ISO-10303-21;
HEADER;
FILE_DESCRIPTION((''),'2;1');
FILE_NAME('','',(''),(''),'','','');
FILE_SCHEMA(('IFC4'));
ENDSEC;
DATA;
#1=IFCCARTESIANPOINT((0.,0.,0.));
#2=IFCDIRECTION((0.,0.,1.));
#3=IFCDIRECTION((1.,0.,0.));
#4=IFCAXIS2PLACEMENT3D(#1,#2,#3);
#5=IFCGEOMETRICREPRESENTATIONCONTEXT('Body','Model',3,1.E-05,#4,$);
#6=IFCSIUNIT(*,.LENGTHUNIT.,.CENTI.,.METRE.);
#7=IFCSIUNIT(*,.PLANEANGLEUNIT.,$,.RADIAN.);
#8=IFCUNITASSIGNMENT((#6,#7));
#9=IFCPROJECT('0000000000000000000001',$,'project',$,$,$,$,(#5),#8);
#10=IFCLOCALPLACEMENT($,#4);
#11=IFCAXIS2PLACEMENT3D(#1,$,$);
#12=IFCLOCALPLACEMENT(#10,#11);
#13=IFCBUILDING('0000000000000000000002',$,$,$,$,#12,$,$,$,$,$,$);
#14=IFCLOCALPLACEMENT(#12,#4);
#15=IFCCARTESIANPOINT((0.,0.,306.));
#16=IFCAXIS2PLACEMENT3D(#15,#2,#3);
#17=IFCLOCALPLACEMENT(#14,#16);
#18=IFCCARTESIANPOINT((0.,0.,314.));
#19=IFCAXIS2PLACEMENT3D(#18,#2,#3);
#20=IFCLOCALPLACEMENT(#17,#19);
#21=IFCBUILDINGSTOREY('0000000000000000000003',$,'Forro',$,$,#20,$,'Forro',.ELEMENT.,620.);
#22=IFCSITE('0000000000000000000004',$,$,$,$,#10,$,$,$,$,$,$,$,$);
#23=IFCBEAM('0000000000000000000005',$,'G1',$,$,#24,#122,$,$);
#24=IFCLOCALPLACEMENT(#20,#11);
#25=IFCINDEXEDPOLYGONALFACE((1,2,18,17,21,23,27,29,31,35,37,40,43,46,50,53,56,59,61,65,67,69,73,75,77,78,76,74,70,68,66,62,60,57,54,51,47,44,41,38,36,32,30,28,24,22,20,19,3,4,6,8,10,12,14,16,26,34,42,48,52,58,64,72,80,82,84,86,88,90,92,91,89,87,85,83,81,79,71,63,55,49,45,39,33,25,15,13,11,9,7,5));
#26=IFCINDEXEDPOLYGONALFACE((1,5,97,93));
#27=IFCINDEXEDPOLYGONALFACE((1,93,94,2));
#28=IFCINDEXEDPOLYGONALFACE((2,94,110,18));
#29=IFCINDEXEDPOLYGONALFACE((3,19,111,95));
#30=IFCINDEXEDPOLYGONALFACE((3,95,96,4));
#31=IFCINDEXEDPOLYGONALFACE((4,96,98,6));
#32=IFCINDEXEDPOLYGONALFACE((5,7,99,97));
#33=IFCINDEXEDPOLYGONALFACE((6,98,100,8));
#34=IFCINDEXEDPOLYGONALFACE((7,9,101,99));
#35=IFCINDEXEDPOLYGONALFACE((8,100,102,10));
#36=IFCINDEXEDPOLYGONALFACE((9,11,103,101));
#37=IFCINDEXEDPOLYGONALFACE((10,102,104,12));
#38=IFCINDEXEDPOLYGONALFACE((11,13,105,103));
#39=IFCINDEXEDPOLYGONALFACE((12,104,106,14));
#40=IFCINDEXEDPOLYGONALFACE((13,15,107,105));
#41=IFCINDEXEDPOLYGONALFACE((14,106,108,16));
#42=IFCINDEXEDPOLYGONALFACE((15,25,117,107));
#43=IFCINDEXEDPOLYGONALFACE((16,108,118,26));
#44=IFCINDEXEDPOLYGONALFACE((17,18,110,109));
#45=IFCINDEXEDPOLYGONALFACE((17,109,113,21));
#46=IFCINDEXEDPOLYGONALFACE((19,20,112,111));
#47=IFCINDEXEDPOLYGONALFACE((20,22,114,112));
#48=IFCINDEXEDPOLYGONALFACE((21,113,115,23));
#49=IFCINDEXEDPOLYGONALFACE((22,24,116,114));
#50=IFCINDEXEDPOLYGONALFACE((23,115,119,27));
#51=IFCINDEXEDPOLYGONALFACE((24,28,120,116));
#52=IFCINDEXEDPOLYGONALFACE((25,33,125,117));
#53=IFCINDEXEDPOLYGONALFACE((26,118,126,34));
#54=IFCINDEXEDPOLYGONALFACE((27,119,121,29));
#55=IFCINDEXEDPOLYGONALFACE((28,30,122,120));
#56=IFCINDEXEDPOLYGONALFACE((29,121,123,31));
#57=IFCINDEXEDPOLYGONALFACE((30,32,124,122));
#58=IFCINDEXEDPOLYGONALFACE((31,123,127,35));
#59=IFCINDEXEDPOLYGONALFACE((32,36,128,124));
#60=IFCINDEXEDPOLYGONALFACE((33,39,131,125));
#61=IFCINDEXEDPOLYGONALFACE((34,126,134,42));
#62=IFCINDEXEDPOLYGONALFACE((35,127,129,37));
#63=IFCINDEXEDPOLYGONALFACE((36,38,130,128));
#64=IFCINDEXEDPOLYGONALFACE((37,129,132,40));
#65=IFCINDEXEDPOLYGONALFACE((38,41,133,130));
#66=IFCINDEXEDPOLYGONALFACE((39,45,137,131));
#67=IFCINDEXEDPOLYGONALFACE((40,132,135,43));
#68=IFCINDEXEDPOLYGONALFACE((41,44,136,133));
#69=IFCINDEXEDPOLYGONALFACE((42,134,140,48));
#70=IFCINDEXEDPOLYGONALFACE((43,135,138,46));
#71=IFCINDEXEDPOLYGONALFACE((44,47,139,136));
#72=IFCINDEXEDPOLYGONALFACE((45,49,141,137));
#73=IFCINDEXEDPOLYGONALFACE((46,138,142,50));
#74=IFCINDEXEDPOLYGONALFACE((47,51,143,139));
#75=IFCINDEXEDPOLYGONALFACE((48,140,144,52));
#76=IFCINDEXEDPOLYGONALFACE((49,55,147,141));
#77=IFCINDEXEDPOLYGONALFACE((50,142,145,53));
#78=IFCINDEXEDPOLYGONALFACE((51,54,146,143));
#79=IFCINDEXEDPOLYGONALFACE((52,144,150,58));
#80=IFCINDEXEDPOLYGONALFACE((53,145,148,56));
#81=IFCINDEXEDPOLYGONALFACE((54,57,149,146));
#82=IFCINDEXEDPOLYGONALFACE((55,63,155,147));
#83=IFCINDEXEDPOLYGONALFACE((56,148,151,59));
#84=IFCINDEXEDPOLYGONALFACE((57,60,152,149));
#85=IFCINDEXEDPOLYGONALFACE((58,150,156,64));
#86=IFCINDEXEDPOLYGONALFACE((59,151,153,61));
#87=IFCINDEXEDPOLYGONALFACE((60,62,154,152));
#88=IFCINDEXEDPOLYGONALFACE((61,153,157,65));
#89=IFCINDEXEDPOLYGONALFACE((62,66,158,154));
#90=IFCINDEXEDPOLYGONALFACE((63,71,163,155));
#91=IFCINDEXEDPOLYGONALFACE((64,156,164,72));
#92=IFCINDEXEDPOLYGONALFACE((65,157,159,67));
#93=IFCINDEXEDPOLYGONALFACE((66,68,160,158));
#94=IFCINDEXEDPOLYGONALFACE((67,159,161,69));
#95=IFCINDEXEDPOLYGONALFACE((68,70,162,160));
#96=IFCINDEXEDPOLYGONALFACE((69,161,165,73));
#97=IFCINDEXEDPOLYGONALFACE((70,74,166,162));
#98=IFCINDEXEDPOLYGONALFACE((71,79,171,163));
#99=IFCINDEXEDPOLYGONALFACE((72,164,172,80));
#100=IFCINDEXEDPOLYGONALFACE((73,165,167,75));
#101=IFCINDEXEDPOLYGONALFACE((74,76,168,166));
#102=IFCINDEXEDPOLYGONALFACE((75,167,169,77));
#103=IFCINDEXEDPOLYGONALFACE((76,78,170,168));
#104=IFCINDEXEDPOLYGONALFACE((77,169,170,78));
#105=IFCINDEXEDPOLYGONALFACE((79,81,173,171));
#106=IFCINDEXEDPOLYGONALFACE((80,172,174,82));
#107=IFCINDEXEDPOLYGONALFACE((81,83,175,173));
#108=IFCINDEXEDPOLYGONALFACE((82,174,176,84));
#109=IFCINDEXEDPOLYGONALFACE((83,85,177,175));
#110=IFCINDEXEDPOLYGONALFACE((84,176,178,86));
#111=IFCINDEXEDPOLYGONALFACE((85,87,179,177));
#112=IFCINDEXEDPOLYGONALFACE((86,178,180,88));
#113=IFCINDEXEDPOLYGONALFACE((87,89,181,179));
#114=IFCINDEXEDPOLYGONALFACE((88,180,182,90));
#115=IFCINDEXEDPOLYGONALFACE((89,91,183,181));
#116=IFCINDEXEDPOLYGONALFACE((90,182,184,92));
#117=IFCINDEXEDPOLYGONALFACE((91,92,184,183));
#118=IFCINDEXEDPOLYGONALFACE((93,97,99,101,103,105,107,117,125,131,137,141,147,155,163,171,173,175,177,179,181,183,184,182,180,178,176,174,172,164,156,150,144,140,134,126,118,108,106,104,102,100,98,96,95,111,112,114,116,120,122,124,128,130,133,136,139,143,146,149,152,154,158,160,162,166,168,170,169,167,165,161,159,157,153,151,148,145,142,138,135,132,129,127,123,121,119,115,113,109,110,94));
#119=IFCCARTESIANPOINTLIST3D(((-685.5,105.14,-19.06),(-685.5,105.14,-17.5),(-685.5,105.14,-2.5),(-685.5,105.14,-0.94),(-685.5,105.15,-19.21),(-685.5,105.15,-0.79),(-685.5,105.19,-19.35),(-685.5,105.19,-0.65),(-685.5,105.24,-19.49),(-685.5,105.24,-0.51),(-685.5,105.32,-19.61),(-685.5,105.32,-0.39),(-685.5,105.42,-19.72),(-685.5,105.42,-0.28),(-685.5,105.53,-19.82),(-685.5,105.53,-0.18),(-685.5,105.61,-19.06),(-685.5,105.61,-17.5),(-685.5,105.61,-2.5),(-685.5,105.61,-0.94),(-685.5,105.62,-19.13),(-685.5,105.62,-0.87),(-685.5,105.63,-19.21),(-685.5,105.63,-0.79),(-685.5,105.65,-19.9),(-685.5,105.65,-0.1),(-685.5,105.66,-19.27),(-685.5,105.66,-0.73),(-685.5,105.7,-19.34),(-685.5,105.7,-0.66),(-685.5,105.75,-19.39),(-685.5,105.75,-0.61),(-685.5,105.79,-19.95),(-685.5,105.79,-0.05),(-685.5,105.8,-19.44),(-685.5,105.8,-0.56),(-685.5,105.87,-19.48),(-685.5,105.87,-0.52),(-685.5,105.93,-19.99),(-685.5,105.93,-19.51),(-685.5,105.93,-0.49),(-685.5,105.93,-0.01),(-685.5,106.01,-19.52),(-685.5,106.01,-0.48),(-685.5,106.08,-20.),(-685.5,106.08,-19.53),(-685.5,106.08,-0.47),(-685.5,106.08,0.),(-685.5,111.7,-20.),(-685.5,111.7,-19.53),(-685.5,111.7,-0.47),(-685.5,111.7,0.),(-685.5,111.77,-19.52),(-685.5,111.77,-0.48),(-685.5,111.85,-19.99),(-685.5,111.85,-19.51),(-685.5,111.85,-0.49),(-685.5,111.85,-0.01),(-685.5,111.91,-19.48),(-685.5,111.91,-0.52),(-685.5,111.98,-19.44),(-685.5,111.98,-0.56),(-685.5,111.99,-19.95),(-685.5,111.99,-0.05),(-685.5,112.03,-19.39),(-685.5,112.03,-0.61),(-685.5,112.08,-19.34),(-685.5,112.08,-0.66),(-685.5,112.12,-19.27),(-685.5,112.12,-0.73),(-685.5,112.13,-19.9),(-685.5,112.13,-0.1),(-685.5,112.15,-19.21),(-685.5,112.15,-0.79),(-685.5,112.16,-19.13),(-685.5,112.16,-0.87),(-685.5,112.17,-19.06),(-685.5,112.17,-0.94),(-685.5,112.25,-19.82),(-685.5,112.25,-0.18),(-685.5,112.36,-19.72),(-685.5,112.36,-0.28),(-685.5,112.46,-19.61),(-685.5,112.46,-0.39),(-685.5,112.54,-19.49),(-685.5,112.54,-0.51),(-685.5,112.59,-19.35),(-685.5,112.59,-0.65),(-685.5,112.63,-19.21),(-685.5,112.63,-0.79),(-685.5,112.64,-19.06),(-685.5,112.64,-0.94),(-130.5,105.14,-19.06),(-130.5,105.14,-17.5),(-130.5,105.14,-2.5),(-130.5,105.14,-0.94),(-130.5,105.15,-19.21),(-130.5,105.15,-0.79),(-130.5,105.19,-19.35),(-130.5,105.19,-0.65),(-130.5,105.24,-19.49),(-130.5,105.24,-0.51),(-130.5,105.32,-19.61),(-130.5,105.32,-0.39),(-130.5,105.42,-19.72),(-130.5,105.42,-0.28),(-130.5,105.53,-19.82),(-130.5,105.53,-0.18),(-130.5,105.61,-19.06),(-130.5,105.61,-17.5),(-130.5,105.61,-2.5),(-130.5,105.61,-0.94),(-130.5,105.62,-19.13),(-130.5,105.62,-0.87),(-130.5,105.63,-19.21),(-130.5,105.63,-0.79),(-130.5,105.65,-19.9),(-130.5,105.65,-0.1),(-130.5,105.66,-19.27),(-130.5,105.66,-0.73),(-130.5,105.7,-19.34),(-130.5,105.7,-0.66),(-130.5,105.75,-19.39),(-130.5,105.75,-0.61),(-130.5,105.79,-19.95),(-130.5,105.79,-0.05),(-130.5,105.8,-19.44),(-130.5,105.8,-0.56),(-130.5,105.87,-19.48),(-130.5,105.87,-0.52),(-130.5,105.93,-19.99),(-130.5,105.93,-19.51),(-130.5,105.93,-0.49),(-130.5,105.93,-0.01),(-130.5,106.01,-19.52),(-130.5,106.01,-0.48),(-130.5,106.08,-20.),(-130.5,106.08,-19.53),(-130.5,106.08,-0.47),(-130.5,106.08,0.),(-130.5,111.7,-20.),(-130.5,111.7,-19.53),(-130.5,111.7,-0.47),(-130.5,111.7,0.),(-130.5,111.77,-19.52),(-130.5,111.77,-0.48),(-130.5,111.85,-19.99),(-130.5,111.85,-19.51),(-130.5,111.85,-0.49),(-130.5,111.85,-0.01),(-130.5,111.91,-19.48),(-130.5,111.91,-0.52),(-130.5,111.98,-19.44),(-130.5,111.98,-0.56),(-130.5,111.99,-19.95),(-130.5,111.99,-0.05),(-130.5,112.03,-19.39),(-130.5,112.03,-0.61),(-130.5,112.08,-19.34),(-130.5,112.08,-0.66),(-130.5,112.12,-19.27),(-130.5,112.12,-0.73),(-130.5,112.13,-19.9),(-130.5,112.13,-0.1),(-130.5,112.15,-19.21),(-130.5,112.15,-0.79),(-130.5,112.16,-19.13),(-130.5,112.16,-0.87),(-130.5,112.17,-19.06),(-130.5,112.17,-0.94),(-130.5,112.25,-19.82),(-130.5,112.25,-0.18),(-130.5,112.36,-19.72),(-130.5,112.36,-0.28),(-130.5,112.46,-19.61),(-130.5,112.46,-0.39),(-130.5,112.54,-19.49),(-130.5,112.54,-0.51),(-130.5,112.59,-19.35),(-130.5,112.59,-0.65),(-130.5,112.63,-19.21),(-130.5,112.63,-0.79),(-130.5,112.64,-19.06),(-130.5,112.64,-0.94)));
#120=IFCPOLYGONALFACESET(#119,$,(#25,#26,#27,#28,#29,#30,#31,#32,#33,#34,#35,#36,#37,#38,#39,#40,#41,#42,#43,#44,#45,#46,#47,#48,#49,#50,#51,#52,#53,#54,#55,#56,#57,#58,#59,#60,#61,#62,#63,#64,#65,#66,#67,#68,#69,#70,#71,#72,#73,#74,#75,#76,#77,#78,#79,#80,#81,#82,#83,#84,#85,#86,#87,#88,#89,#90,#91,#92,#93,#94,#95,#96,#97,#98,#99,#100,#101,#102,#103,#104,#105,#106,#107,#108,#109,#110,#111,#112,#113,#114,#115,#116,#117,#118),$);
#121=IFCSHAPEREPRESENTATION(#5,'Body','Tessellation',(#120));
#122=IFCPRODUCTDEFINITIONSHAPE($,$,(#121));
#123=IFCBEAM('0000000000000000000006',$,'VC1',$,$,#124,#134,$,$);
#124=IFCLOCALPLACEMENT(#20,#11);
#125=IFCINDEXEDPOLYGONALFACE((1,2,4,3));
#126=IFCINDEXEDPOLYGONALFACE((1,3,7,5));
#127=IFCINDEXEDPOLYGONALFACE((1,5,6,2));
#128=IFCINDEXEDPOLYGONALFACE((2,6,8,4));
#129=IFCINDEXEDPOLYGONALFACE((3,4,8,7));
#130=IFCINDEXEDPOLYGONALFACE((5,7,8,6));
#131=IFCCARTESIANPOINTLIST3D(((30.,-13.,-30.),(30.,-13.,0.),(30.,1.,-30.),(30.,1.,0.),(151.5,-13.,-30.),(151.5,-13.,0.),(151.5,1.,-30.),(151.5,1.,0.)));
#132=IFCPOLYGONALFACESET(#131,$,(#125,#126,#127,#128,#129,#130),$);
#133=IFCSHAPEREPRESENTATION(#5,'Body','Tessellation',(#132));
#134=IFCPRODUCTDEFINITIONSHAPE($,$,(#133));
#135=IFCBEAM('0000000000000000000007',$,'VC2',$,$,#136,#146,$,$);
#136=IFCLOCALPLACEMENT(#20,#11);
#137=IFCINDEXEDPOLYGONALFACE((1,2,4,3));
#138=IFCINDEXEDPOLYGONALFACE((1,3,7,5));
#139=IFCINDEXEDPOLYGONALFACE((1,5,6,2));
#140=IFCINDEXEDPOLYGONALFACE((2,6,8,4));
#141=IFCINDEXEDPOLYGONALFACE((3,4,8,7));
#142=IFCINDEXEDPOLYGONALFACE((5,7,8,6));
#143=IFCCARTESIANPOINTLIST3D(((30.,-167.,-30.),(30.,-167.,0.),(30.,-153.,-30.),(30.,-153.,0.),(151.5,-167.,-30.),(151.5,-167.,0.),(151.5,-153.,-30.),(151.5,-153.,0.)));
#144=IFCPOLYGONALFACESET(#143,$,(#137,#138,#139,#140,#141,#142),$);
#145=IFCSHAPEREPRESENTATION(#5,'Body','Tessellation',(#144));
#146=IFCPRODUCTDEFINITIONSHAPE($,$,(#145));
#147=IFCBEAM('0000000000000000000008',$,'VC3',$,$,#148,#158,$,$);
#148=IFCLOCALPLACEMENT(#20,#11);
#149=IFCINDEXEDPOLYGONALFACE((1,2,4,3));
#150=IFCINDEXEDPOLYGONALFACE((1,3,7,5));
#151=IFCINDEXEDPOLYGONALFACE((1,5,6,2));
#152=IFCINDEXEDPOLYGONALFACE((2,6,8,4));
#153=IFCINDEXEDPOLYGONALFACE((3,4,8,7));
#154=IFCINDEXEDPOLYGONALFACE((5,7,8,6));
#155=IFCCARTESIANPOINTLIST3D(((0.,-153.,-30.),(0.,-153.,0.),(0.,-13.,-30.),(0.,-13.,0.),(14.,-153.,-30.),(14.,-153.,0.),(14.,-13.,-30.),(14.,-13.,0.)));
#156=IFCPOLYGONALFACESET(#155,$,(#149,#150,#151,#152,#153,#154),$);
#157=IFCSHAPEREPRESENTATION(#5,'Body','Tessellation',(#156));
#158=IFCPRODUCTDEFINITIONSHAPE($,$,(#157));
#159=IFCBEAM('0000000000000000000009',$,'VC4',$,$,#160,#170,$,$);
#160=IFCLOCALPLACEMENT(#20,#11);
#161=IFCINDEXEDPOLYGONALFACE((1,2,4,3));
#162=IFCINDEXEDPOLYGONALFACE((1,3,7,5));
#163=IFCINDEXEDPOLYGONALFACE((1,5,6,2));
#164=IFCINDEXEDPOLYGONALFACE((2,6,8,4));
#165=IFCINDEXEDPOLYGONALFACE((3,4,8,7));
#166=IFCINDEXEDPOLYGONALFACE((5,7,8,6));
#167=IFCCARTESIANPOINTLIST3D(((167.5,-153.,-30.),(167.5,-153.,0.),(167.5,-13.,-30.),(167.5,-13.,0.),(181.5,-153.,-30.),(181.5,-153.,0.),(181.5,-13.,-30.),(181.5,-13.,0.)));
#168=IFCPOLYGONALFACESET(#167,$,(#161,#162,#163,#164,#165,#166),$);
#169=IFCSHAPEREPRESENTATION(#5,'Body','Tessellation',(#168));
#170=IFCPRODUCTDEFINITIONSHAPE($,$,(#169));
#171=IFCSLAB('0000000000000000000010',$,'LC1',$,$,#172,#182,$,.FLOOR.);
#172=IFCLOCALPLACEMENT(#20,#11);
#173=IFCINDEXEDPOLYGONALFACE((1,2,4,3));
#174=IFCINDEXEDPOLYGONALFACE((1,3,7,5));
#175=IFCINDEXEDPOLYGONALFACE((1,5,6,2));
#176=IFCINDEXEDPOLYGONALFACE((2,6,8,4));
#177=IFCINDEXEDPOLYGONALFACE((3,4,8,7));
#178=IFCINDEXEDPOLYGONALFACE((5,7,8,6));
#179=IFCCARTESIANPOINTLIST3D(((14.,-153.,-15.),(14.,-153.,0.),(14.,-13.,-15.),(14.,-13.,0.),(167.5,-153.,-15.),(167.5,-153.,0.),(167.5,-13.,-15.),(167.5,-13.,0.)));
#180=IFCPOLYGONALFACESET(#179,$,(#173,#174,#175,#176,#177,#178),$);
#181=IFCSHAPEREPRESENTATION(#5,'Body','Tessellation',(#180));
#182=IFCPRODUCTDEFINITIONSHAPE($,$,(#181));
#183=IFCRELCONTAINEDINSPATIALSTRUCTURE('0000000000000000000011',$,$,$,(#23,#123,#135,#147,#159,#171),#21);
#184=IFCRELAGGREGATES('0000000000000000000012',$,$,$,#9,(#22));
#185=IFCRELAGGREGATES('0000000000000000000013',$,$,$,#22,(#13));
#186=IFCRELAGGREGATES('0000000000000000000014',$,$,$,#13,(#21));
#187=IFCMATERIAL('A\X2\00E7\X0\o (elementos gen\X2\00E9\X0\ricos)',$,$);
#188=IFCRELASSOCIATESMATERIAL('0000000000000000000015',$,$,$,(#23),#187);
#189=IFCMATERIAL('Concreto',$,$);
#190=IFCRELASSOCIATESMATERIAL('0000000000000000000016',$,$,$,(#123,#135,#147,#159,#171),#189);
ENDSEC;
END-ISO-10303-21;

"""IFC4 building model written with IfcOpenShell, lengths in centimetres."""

from ifc_helpers import new_model, si_unit, frame, origin, origin_with_axes, origin_2d_with_axis, place, context, project, spatial, polyline, rectangle, outline, extrude, material, element, save


model = new_model("IFC4")

# Units and contexts
model_context = context("Model", 3, precision=1e-05, world=origin_with_axes(), identifier="Body")
ifc_project = project(units=[si_unit("LENGTHUNIT", "METRE", prefix="CENTI"), si_unit("PLANEANGLEUNIT", "RADIAN")], contexts=[model_context])

# Site, building, storey
site_placement = place(None, origin_with_axes())
site = spatial("IfcSite", under=ifc_project, at=site_placement)
building_placement = place(site_placement, origin())
building = spatial("IfcBuilding", under=site, at=building_placement)
placement_1 = place(building_placement, origin_with_axes())
placement_2 = place(placement_1, frame((0.0, 0.0, 306.0), z_axis=(0.0, 0.0, 1.0), x_axis=(1.0, 0.0, 0.0)))
storey_placement = place(placement_2, frame((0.0, 0.0, 314.0), z_axis=(0.0, 0.0, 1.0), x_axis=(1.0, 0.0, 0.0)))
storey = spatial("IfcBuildingStorey", under=building, at=storey_placement, Name="Forro", LongName="Forro", CompositionType="ELEMENT", Elevation=620.0)

# Shared definitions
ifc_material_1 = material(Name="Concreto")

# Beams
ifc_material_2 = material(Name="Aço (elementos genéricos)")
beam_1_placement = place(storey_placement, frame((-408.0, 108.89, 0.0), z_axis=(0.0, 0.0, 1.0), x_axis=(1.0, 0.0, 0.0)))
element("IfcBeam", 1, at=beam_1_placement, inside=storey, material=ifc_material_2, Name="G1", context=model_context, shape_type="SolidModel", body=[
    extrude(outline(polyline([(-3.75, -9.06), (-3.74, -9.21), (-3.7, -9.35), (-3.65, -9.49), (-3.57, -9.61), (-3.47, -9.72), (-3.36, -9.82), (-3.24, -9.9), (-3.1, -9.95), (-2.96, -9.99), (-2.81, -10.0), (2.81, -10.0), (2.96, -9.99), (3.1, -9.95), (3.24, -9.9), (3.36, -9.82), (3.47, -9.72), (3.57, -9.61), (3.65, -9.49), (3.7, -9.35), (3.74, -9.21), (3.75, -9.06), (3.75, -7.5), (3.28, -7.5), (3.28, -9.06), (3.27, -9.13), (3.26, -9.21), (3.23, -9.27), (3.19, -9.34), (3.14, -9.39), (3.09, -9.44), (3.02, -9.48), (2.96, -9.51), (2.88, -9.52), (2.81, -9.53), (-2.81, -9.53), (-2.88, -9.52), (-2.96, -9.51), (-3.02, -9.48), (-3.09, -9.44), (-3.14, -9.39), (-3.19, -9.34), (-3.23, -9.27), (-3.26, -9.21), (-3.27, -9.13), (-3.28, -9.06), (-3.28, 9.06), (-3.27, 9.13), (-3.26, 9.21), (-3.23, 9.27), (-3.19, 9.34), (-3.14, 9.39), (-3.09, 9.44), (-3.02, 9.48), (-2.96, 9.51), (-2.88, 9.52), (-2.81, 9.53), (2.81, 9.53), (2.88, 9.52), (2.96, 9.51), (3.02, 9.48), (3.09, 9.44), (3.14, 9.39), (3.19, 9.34), (3.23, 9.27), (3.26, 9.21), (3.27, 9.13), (3.28, 9.06), (3.28, 7.5), (3.75, 7.5), (3.75, 9.06), (3.74, 9.21), (3.7, 9.35), (3.65, 9.49), (3.57, 9.61), (3.47, 9.72), (3.36, 9.82), (3.24, 9.9), (3.1, 9.95), (2.96, 9.99), (2.81, 10.0), (-2.81, 10.0), (-2.96, 9.99), (-3.1, 9.95), (-3.24, 9.9), (-3.36, 9.82), (-3.47, 9.72), (-3.57, 9.61), (-3.65, 9.49), (-3.7, 9.35), (-3.74, 9.21), (-3.75, 9.06), (-3.75, -9.06)])), frame((-277.5, 0.0, -10.0), z_axis=(1.0, 0.0, 0.0), x_axis=(0.0, -1.0, 0.0)), (0.0, 0.0, 1.0), 555.0),
])
beam_2_placement = place(storey_placement, frame((90.75, -6.0, 0.0), z_axis=(0.0, 0.0, 1.0), x_axis=(1.0, 0.0, 0.0)))
element("IfcBeam", 2, at=beam_2_placement, inside=storey, material=ifc_material_1, Name="VC1", context=model_context, shape_type="SolidModel", body=[
    extrude(rectangle(XDim=14.0, YDim=30.0, at=origin_2d_with_axis()), frame((-60.75, 0.0, -15.0), z_axis=(1.0, 0.0, 0.0), x_axis=(0.0, 1.0, 0.0)), (0.0, 0.0, 1.0), 121.5),
])
beam_3_placement = place(storey_placement, frame((90.75, -160.0, 0.0), z_axis=(0.0, 0.0, 1.0), x_axis=(1.0, 0.0, 0.0)))
element("IfcBeam", 3, at=beam_3_placement, inside=storey, material=ifc_material_1, Name="VC2", context=model_context, shape_type="SolidModel", body=[
    extrude(rectangle(XDim=14.0, YDim=30.0, at=origin_2d_with_axis()), frame((-60.75, 0.0, -15.0), z_axis=(1.0, 0.0, 0.0), x_axis=(0.0, -1.0, 0.0)), (0.0, 0.0, 1.0), 121.5),
])
for number, where, z_axis, x_axis, name in (
    (4, (7.0, -83.0, 0.0), (0.0, 0.0, 1.0), (1.0, 0.0, 0.0), "VC3"),
    (5, (174.5, -83.0, 0.0), (0.0, 0.0, 1.0), (1.0, 0.0, 0.0), "VC4"),
):
    element("IfcBeam", number, at=place(storey_placement, frame(where, z_axis=z_axis, x_axis=x_axis)), inside=storey, material=ifc_material_1, Name=name, context=model_context, shape_type="SolidModel", body=[
        extrude(rectangle(XDim=14.0, YDim=30.0, at=origin_2d_with_axis()), frame((0.0, -70.0, -15.0), z_axis=(0.0, 1.0, 0.0), x_axis=(1.0, 0.0, 0.0)), (0.0, 0.0, 1.0), 140.0),
    ])

# Slab
slab_placement = place(storey_placement, frame((90.75, -83.0, 0.0), z_axis=(0.0, 0.0, 1.0), x_axis=(1.0, 0.0, 0.0)))
element("IfcSlab", 6, at=slab_placement, inside=storey, material=ifc_material_1, Name="LC1", PredefinedType="FLOOR", context=model_context, shape_type="SolidModel", body=[
    extrude(outline(polyline([(76.75, 70.0), (-76.75, 70.0), (-76.75, -70.0), (76.75, -70.0), (76.75, 70.0), (76.75, 70.0)])), frame((0.0, 0.0, -15.0), z_axis=(0.0, 0.0, 1.0), x_axis=(1.0, 0.0, 0.0)), (0.0, 0.0, 1.0), 15.0),
])

save(model, "model.ifc")
